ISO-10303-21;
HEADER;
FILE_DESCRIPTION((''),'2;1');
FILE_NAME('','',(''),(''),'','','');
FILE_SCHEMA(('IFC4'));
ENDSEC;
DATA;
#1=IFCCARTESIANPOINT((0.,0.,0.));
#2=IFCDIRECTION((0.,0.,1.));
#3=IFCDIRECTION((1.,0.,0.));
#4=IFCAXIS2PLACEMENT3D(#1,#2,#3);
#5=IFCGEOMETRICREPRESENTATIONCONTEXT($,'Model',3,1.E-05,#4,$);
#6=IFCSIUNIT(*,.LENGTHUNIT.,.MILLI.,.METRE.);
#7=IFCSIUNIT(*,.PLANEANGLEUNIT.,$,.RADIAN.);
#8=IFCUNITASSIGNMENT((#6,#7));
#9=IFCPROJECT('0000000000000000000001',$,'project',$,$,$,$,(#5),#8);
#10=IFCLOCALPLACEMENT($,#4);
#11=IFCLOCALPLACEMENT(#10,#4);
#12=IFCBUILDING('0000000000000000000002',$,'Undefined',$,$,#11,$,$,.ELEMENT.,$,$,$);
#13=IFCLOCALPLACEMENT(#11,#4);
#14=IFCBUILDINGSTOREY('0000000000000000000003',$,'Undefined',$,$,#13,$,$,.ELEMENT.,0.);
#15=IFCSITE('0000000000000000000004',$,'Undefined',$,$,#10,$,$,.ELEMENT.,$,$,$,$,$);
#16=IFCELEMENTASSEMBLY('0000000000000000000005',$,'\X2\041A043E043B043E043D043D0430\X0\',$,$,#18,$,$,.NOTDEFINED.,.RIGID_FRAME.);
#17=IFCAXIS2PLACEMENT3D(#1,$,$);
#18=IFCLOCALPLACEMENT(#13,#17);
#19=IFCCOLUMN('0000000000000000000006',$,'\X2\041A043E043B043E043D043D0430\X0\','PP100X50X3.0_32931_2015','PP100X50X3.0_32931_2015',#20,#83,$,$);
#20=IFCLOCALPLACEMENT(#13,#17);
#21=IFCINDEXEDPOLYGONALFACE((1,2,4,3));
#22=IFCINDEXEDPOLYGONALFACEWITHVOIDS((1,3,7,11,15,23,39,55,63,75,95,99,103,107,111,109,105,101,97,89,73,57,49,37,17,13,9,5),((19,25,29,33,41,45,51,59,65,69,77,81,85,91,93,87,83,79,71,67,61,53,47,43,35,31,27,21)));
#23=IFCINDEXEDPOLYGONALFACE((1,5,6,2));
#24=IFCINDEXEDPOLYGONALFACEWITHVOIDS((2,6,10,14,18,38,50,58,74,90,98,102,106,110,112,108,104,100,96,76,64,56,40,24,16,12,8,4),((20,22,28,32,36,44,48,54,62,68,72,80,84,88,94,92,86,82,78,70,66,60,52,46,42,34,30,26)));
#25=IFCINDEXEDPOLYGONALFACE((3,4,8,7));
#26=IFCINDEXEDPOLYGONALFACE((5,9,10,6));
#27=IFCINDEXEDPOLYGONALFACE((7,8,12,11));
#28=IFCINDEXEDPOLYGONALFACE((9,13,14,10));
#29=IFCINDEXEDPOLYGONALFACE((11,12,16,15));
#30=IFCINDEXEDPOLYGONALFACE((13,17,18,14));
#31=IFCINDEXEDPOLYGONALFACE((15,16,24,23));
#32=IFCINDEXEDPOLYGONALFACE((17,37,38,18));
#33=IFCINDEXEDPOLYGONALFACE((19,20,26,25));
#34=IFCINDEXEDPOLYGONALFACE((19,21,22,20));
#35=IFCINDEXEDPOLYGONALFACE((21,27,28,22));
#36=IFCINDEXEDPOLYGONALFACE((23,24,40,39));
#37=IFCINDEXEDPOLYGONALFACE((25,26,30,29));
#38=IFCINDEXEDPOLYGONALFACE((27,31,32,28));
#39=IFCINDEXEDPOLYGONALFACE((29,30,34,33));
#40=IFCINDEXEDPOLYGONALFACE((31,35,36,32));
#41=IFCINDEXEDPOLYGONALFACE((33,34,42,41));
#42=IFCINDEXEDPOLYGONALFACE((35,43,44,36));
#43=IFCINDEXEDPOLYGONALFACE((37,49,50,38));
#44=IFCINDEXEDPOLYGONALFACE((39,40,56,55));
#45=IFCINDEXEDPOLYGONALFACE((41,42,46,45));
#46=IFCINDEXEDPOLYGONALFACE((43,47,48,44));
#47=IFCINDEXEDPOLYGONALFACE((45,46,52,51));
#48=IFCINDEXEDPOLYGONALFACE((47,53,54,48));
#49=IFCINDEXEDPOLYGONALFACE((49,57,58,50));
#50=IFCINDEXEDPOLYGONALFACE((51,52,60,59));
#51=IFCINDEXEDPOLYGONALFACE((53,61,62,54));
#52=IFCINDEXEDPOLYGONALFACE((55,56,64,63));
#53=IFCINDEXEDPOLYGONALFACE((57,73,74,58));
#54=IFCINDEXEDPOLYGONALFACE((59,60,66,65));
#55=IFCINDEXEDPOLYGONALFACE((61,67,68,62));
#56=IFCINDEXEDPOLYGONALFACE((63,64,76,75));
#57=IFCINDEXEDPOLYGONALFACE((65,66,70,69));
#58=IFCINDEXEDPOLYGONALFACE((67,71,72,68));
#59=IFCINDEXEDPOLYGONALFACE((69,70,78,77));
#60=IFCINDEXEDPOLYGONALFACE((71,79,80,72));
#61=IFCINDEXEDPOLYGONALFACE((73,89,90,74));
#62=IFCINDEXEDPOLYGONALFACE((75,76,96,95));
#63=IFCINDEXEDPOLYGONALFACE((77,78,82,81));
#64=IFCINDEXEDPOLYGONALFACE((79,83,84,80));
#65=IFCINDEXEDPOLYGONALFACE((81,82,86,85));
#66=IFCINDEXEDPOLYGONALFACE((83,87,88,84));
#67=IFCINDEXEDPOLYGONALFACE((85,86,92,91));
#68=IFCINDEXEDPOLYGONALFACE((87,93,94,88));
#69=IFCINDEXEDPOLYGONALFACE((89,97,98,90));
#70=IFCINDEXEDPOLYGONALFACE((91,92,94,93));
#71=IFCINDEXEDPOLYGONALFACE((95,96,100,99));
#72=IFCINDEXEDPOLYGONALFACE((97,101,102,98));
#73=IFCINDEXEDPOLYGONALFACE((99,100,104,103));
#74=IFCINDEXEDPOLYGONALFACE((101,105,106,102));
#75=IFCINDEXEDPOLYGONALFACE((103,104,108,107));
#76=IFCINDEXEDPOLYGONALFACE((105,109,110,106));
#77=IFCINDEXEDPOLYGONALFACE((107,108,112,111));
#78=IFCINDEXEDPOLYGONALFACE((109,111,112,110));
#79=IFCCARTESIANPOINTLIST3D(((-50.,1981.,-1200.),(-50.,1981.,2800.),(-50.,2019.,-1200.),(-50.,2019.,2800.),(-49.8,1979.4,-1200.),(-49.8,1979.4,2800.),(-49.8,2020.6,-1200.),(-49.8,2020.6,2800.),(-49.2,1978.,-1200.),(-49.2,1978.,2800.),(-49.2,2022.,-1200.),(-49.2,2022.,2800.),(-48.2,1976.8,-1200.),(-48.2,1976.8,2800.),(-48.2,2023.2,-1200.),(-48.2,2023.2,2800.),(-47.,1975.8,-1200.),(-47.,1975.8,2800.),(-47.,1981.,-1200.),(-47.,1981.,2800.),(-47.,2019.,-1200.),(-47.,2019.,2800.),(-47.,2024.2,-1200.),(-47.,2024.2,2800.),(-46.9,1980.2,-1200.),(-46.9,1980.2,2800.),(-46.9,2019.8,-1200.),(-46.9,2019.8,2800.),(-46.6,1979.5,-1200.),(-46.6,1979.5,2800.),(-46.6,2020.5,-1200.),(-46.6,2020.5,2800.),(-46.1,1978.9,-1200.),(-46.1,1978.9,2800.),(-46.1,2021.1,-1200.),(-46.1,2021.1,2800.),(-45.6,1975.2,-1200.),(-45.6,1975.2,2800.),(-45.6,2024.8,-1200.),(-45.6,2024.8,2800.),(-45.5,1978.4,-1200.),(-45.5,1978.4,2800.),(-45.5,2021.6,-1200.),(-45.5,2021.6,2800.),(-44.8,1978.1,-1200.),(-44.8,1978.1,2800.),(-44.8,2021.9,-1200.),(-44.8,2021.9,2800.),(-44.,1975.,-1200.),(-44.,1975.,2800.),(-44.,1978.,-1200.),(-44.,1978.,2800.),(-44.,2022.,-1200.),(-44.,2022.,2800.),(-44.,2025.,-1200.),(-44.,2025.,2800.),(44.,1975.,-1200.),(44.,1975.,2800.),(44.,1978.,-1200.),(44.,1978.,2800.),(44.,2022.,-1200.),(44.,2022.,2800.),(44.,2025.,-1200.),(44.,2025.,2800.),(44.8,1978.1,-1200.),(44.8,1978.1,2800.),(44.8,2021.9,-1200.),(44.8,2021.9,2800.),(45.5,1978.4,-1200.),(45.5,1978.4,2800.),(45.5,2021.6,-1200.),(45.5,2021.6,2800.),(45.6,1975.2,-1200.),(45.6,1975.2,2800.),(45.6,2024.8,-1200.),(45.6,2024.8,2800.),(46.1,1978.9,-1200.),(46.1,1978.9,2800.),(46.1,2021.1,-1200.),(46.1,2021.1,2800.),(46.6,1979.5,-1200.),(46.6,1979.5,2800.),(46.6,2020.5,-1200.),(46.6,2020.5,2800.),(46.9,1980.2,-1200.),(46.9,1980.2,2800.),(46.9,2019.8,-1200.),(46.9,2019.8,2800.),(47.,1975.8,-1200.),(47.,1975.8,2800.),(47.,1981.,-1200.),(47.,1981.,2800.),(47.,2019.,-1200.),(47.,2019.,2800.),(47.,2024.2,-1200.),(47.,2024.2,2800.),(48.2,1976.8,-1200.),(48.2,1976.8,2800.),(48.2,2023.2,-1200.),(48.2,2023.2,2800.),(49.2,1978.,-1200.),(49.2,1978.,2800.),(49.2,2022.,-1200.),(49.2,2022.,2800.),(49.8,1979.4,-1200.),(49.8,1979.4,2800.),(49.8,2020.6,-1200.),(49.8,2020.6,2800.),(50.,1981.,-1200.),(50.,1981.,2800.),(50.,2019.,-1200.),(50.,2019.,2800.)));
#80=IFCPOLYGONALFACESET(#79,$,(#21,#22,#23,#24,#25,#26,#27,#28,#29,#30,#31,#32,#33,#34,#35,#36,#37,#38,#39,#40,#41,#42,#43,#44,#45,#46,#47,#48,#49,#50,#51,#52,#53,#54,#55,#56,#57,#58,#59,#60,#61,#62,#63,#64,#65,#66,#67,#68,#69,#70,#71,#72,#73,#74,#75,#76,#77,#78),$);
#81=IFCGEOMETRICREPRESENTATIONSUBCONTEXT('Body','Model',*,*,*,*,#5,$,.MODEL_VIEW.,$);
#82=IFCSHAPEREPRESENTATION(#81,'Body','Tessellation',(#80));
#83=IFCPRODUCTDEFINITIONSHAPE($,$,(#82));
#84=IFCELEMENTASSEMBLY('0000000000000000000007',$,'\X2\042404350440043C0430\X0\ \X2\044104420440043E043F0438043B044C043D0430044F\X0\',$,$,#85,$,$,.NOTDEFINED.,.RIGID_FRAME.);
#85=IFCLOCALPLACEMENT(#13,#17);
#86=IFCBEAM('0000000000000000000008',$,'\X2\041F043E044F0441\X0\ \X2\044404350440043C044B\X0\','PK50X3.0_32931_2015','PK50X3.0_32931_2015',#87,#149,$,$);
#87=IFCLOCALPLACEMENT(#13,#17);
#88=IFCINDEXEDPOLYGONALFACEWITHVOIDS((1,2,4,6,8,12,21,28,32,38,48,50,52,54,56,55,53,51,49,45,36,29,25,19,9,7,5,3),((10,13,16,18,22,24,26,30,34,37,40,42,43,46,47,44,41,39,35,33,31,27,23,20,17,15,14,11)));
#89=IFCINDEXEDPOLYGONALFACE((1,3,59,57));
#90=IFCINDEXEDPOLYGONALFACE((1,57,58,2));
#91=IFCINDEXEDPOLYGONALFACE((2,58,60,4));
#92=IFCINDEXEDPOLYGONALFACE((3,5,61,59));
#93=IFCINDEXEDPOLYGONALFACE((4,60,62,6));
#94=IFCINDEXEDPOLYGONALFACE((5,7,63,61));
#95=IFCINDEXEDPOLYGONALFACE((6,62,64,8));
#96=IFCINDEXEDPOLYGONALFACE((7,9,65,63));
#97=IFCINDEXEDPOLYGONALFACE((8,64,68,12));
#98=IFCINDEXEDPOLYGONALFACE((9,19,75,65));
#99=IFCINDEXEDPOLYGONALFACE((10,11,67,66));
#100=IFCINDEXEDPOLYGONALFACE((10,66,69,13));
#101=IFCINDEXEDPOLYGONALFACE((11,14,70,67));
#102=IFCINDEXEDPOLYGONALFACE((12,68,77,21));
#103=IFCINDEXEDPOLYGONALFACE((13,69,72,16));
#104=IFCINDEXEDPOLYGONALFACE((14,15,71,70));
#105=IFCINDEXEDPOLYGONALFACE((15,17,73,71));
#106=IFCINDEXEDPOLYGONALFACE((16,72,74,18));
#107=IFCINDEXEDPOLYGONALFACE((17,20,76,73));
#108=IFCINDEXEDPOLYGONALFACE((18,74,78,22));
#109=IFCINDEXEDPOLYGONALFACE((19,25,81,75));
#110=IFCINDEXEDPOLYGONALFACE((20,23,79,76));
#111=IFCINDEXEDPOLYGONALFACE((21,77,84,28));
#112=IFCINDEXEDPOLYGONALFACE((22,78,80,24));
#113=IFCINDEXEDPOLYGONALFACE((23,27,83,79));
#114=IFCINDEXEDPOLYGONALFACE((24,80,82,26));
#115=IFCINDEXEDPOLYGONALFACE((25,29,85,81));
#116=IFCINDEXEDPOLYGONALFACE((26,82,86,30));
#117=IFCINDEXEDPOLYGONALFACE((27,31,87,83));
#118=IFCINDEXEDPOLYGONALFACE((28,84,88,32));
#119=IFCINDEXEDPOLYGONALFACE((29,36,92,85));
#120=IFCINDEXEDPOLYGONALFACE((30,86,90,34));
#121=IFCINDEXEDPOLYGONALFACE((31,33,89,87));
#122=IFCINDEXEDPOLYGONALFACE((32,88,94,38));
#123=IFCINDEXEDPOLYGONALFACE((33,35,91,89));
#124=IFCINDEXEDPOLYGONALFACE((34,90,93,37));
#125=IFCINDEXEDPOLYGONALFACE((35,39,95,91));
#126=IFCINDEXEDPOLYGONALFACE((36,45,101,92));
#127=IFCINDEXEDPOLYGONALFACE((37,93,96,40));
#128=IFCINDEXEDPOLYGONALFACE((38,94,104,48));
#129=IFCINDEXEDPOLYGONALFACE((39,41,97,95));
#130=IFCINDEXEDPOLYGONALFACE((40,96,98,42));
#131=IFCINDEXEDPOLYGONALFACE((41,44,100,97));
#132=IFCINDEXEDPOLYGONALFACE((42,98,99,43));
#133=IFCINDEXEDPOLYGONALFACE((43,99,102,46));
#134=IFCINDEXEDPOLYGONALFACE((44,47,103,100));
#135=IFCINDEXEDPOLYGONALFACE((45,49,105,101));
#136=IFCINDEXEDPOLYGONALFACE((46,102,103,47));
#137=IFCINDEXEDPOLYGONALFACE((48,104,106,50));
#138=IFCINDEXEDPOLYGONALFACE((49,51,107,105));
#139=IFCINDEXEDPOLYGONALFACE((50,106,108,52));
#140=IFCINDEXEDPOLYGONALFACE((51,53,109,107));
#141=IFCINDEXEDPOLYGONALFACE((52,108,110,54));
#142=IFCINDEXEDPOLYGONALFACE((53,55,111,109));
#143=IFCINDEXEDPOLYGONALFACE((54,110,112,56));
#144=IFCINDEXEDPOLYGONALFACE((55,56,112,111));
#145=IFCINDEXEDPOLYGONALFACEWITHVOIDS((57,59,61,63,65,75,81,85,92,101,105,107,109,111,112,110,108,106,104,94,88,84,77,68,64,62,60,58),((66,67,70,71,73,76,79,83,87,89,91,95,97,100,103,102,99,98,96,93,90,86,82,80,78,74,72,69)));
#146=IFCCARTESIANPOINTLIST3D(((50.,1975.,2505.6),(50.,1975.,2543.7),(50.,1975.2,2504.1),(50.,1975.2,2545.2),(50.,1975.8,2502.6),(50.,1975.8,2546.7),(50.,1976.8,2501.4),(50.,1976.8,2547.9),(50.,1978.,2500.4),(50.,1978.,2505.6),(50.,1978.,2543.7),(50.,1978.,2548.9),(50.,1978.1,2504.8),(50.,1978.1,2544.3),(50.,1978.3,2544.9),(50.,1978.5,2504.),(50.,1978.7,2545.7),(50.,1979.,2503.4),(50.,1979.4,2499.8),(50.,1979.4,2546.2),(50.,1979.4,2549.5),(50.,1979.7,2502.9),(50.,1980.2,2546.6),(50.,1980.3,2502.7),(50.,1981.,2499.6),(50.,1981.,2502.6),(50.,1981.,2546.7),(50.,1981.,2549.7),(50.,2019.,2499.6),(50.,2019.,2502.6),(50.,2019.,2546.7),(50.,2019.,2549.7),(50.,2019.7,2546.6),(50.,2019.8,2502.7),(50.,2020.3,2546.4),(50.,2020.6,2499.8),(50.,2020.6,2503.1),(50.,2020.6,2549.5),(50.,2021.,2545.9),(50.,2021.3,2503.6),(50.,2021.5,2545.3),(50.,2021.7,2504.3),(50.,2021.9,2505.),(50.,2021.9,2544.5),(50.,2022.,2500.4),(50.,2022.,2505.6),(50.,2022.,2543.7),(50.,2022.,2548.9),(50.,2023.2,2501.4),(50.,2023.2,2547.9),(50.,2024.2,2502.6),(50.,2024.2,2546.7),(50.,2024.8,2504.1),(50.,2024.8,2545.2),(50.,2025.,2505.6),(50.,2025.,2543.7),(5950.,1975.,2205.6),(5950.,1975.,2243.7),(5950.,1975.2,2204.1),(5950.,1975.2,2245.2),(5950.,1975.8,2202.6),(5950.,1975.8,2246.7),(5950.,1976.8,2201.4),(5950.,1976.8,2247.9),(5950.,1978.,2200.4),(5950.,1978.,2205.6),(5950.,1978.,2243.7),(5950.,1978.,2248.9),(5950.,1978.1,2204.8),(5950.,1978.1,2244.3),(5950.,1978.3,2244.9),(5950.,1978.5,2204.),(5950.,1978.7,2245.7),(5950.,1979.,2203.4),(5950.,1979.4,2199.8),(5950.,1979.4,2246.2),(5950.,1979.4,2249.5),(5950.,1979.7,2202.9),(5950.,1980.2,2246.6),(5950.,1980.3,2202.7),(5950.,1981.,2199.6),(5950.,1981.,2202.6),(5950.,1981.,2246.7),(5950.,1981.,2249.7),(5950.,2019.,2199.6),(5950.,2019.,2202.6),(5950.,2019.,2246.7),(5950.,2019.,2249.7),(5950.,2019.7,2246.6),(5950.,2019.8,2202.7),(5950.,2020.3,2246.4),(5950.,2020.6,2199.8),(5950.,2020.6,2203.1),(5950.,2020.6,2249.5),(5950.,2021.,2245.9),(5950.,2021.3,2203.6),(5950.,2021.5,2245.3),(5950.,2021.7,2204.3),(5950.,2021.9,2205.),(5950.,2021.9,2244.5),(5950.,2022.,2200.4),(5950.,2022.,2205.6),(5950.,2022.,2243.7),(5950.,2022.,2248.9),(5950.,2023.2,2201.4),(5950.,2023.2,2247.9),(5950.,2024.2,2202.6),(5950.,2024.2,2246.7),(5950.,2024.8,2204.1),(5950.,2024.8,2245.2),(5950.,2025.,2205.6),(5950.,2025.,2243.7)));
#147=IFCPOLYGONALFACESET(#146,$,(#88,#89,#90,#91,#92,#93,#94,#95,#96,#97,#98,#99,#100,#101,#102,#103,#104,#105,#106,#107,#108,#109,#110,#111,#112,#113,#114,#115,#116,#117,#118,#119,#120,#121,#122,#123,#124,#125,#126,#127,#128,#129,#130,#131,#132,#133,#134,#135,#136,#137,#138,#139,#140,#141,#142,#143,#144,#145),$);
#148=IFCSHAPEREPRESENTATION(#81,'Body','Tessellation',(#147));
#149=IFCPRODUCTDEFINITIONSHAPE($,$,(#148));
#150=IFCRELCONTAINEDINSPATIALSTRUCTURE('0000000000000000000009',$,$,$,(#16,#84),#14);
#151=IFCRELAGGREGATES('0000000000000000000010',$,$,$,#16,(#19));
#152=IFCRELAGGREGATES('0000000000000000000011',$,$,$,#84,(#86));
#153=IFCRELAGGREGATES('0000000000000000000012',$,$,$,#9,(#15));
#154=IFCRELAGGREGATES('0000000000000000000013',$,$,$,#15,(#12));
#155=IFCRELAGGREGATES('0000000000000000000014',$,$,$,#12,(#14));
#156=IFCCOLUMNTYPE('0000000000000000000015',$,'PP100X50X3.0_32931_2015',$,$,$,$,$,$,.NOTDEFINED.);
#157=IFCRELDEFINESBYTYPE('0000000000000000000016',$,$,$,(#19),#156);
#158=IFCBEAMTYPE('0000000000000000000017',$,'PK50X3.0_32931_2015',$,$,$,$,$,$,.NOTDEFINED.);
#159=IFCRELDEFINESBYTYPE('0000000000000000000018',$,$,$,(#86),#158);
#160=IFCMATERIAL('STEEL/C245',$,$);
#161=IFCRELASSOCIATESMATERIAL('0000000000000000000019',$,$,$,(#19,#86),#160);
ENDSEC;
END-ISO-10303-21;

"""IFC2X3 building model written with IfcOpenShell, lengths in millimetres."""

from ifc_helpers import new_model, si_unit, frame, origin_with_axes, origin_2d_with_axis, place, context, subcontext, project, spatial, hollow_rectangle, extrude, clip, halfspace, material, type_object, element, aggregate, save


model = new_model("IFC2X3")

# Units and contexts
model_context = context("Model", 3, precision=1e-05, world=origin_with_axes())
body_context = subcontext(model_context, "Body", "Model", "MODEL_VIEW")
ifc_project = project(units=[si_unit("LENGTHUNIT", "METRE", prefix="MILLI"), si_unit("PLANEANGLEUNIT", "RADIAN")], contexts=[model_context])

# Site, building, storey
site_placement = place(None, origin_with_axes())
site = spatial("IfcSite", under=ifc_project, at=site_placement, Name="Undefined", CompositionType="ELEMENT")
building_placement = place(site_placement, origin_with_axes())
building = spatial("IfcBuilding", under=site, at=building_placement, Name="Undefined", CompositionType="ELEMENT")
storey_placement = place(building_placement, origin_with_axes())
storey = spatial("IfcBuildingStorey", under=building, at=storey_placement, Name="Undefined", CompositionType="ELEMENT", Elevation=0.0)

# Element assembly, column
ifc_material_1 = material(Name="STEEL/C245")
column_type_1 = type_object("IfcColumnType", Name="PP100X50X3.0_32931_2015", PredefinedType="NOTDEFINED")
assembly_1_placement = place(storey_placement, origin_with_axes())
assembly_1 = element("IfcElementAssembly", 1, at=assembly_1_placement, inside=storey, Name="Колонна", AssemblyPlace="NOTDEFINED", PredefinedType="RIGID_FRAME")
column_1_placement = place(assembly_1_placement, frame((0.0, 2000.0, -1200.0), z_axis=(0.0, 0.0, 1.0), x_axis=(-1.0, 0.0, 0.0)))
column_1 = element("IfcColumn", 2, at=column_1_placement, type_object=column_type_1, material=ifc_material_1, Name="Колонна", Description="PP100X50X3.0_32931_2015", ObjectType="PP100X50X3.0_32931_2015", context=body_context, shape_type="SweptSolid", body=[
    extrude(hollow_rectangle(XDim=50.0, YDim=100.0, WallThickness=3.0, InnerFilletRadius=3.0, OuterFilletRadius=6.0, at=origin_2d_with_axis()), frame((0.0, 0.0, 4000.0), z_axis=(0.0, 0.0, -1.0), x_axis=(0.0, 1.0, 0.0)), (0.0, 0.0, 1.0), 4000.0),
])
aggregate(assembly_1, [column_1])

# Element assembly, beam
assembly_2_placement = place(storey_placement, origin_with_axes())
assembly_2 = element("IfcElementAssembly", 3, at=assembly_2_placement, inside=storey, Name="Ферма стропильная", AssemblyPlace="NOTDEFINED", PredefinedType="RIGID_FRAME")
beam_type_1 = type_object("IfcBeamType", Name="PK50X3.0_32931_2015", PredefinedType="NOTDEFINED")
beam_1_placement = place(assembly_2_placement, frame((36.0, 2000.0, 2525.4), z_axis=(0.050782, 0.0, 0.99871), x_axis=(0.99871, 0.0, -0.050782)))
beam_1 = element("IfcBeam", 4, at=beam_1_placement, type_object=beam_type_1, material=ifc_material_1, Name="Пояс фермы", Description="PK50X3.0_32931_2015", ObjectType="PK50X3.0_32931_2015", context=body_context, shape_type="Clipping", body=[
    clip(clip(extrude(hollow_rectangle(XDim=50.0, YDim=50.0, WallThickness=3.0, InnerFilletRadius=3.0, OuterFilletRadius=6.0, at=origin_2d_with_axis()), frame((5924.2, 0.0, 0.0), z_axis=(-1.0, 0.0, 0.0), x_axis=(0.0, -1.0, 0.0)), (0.0, 0.0, 1.0), 5912.8), halfspace(frame((5907.6, 0.0, 275.0), z_axis=(0.99871, 0.0, 0.050782), x_axis=(0.0, -1.0, 0.0)), False)), halfspace(frame((0.0, 0.0, 275.0), z_axis=(0.99871, 0.0, 0.050782), x_axis=(0.0, -1.0, 0.0)), True)),
])
aggregate(assembly_2, [beam_1])

save(model, "model.ifc")
